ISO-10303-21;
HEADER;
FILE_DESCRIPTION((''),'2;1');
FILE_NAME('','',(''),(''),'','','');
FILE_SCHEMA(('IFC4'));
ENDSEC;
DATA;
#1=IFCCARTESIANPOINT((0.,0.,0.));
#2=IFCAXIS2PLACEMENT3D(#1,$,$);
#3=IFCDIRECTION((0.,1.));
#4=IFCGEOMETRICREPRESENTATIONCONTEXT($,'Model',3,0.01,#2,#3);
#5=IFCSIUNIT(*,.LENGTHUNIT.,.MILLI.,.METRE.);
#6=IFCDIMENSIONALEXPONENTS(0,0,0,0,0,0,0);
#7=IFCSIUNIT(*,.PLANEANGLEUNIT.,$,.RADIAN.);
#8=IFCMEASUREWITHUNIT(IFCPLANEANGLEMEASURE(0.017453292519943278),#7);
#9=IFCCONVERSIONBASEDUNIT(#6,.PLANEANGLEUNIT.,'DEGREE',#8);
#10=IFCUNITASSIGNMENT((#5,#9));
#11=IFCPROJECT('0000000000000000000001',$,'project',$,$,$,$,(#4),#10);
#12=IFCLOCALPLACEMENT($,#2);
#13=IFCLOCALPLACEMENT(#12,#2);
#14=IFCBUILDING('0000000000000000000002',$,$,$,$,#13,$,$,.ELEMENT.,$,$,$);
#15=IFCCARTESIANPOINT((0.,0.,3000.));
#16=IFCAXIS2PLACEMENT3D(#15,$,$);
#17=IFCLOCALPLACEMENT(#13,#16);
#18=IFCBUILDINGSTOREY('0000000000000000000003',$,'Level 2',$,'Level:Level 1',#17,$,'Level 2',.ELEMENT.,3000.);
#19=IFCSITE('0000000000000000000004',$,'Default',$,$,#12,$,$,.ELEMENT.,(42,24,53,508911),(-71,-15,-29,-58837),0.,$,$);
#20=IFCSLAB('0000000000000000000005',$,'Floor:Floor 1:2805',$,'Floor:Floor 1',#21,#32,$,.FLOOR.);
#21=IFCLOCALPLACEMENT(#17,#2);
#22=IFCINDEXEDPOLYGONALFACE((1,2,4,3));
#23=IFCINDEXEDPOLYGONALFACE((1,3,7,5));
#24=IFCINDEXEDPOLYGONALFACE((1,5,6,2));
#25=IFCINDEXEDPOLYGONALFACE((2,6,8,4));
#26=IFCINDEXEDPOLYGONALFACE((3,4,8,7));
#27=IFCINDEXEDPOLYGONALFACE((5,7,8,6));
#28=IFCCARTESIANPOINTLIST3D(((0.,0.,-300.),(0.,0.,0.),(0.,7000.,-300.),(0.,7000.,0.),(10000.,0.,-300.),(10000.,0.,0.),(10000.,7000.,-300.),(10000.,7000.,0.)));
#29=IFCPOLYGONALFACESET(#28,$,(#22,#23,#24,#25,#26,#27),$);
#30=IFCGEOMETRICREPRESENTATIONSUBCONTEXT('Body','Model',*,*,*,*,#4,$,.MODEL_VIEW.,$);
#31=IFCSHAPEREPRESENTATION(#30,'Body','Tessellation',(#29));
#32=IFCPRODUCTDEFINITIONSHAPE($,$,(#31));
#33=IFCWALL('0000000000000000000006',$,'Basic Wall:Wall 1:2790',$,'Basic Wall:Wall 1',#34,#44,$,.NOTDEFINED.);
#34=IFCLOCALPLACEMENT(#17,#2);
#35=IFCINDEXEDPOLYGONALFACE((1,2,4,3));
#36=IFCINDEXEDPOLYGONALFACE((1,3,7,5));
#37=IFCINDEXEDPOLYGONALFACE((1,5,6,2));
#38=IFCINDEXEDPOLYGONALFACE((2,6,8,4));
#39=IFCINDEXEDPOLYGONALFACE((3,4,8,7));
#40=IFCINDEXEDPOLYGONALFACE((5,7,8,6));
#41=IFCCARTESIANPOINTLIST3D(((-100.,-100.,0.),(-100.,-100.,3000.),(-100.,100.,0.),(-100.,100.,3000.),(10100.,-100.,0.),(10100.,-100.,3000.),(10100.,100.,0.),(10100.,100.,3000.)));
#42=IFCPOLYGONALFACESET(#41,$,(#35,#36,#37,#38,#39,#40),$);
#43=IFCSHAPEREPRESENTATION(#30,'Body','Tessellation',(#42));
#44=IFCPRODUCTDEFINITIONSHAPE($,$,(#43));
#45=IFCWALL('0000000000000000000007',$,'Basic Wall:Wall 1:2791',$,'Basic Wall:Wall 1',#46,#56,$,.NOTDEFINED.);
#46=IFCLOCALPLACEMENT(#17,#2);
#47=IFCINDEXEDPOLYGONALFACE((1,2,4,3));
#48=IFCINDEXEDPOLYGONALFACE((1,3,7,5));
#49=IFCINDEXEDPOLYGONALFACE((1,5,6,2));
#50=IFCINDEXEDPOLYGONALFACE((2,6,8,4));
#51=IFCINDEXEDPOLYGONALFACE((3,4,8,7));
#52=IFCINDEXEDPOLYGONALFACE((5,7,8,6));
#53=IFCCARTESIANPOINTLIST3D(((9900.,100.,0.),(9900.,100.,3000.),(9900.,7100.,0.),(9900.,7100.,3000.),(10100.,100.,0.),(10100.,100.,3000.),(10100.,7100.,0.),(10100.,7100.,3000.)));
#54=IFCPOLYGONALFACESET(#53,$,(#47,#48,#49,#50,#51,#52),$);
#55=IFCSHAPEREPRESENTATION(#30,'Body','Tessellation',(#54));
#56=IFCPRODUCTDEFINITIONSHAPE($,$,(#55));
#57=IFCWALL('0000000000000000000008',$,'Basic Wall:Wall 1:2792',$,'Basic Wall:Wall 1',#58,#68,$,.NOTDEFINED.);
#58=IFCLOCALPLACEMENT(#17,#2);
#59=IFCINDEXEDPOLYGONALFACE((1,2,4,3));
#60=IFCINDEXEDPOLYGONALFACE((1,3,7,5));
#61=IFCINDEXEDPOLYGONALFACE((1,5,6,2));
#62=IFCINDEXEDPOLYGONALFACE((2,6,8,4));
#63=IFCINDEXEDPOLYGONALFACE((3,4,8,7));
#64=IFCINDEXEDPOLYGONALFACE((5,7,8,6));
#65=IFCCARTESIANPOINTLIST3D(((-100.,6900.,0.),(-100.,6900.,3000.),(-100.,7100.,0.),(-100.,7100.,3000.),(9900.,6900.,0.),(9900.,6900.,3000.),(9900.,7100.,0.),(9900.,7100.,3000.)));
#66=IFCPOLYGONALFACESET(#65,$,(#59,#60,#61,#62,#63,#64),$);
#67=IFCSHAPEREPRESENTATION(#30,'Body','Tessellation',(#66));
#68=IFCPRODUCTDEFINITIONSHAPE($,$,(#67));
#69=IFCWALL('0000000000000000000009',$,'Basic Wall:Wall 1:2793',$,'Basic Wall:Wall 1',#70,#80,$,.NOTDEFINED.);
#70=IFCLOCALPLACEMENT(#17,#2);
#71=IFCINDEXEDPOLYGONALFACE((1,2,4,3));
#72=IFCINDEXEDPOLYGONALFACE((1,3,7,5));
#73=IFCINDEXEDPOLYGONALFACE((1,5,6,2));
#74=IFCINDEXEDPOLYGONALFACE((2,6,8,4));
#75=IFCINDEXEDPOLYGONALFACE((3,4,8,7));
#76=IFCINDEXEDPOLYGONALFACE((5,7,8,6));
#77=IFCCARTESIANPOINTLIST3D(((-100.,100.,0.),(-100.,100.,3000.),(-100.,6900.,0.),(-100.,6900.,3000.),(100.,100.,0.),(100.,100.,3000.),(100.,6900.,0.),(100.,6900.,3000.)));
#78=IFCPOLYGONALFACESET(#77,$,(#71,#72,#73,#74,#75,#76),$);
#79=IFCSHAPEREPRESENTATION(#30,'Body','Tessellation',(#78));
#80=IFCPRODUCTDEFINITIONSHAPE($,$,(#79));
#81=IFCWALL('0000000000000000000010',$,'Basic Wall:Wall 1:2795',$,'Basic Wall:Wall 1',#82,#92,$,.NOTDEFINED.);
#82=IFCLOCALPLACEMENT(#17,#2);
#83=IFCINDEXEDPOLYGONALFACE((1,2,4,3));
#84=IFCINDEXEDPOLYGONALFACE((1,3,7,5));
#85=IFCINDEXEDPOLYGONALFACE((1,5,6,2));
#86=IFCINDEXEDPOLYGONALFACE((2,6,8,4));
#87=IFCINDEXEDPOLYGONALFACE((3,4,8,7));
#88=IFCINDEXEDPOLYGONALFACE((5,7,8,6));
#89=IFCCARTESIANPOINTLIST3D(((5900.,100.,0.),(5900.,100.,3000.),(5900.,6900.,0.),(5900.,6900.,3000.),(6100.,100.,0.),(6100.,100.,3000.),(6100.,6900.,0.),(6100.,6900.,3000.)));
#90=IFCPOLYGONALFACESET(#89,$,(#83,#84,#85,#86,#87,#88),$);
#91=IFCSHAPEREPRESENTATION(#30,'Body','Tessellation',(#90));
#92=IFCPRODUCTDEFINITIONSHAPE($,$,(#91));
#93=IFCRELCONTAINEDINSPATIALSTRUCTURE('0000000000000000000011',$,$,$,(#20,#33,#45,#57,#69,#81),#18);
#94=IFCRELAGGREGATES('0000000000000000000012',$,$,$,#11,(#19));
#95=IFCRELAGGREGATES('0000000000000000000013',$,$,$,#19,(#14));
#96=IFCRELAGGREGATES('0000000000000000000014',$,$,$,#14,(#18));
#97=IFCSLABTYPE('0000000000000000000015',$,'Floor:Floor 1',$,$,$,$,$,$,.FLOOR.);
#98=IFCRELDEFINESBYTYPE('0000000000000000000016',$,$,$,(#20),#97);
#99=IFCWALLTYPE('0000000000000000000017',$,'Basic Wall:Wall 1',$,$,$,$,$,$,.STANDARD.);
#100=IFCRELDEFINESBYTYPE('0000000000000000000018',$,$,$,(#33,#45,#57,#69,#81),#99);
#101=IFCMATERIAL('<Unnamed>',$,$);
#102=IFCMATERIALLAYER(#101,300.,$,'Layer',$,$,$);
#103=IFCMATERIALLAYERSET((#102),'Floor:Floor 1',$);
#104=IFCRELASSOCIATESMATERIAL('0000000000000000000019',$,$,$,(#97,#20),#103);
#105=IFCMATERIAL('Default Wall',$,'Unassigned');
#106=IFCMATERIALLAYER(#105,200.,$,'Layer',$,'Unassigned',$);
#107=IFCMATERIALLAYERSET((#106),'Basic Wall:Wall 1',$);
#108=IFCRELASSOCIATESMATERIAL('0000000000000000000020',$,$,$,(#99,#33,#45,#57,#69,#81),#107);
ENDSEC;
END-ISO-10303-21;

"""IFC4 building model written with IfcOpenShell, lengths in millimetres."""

from ifc_helpers import new_model, entity, si_unit, converted_unit, direction, frame, frame_2d, origin, origin_2d_with_axis, place, context, subcontext, project, spatial, rectangle, extrude, material, layer, layer_set, layer_usage, type_object, element, save


model = new_model("IFC4")

# Units and contexts
model_context = context("Model", 3, precision=0.01, world=origin(), true_north=direction((0.0, 1.0)))
body_context = subcontext(model_context, "Body", "Model", "MODEL_VIEW")
ifc_project = project(units=[si_unit("LENGTHUNIT", "METRE", prefix="MILLI"), converted_unit("PLANEANGLEUNIT", "DEGREE", entity("IfcPlaneAngleMeasure", 0.017453292519943278), si_unit("PLANEANGLEUNIT", "RADIAN"), dimensions=[0, 0, 0, 0, 0, 0, 0])], contexts=[model_context])

# Site, building, storey
site_placement = place(None, origin())
site = spatial("IfcSite", under=ifc_project, at=site_placement, Name="Default", CompositionType="ELEMENT", RefLatitude=(42, 24, 53, 508911), RefLongitude=(-71, -15, -29, -58837), RefElevation=0.0)
building_placement = place(site_placement, origin())
building = spatial("IfcBuilding", under=site, at=building_placement, CompositionType="ELEMENT")
storey_placement = place(building_placement, frame((0.0, 0.0, 3000.0)))
storey = spatial("IfcBuildingStorey", under=building, at=storey_placement, Name="Level 2", ObjectType="Level:Level 1", LongName="Level 2", CompositionType="ELEMENT", Elevation=3000.0)

# Slab
ifc_material_1 = material(Name="<Unnamed>")
ifc_layer_1 = layer(ifc_material_1, 300.0, Name="Layer")
ifc_layer_set_1 = layer_set([ifc_layer_1], Name="Floor:Floor 1")
ifc_layer_usage_1 = layer_usage(ifc_layer_set_1, "AXIS3", "POSITIVE", 0.0)
slab_type = type_object("IfcSlabType", Name="Floor:Floor 1", PredefinedType="FLOOR", material=ifc_layer_set_1)
slab_placement = place(storey_placement, origin())
element("IfcSlab", 1, at=slab_placement, inside=storey, type_object=slab_type, material=ifc_layer_usage_1, Name="Floor:Floor 1:2805", ObjectType="Floor:Floor 1", PredefinedType="FLOOR", context=body_context, shape_type="SweptSolid", body=[
    extrude(rectangle(XDim=7000.0, YDim=10000.0, at=origin_2d_with_axis()), frame((5000.0, 3500.0, 0.0), z_axis=(0.0, 0.0, -1.0), x_axis=(0.0, 1.0, 0.0)), (0.0, 0.0, 1.0), 300.0),
])

# Walls
ifc_material_2 = material(Name="Default Wall", Category="Unassigned")
ifc_layer_2 = layer(ifc_material_2, 200.0, Name="Layer", Category="Unassigned")
ifc_layer_set_2 = layer_set([ifc_layer_2], Name="Basic Wall:Wall 1")
ifc_layer_usage_2 = layer_usage(ifc_layer_set_2, "AXIS2", "NEGATIVE", 100.0)
wall_type = type_object("IfcWallType", Name="Basic Wall:Wall 1", PredefinedType="STANDARD", material=ifc_layer_set_2)
wall_1_placement = place(storey_placement, frame((-100.0, 0.0, 0.0)))
element("IfcWall", 2, at=wall_1_placement, inside=storey, type_object=wall_type, material=ifc_layer_usage_2, Name="Basic Wall:Wall 1:2790", ObjectType="Basic Wall:Wall 1", PredefinedType="NOTDEFINED", context=body_context, shape_type="SweptSolid", body=[
    extrude(rectangle(XDim=10200.0, YDim=200.0, at=frame_2d((5100.0, 0.0), x_axis=(-1.0, 0.0))), origin(), (0.0, 0.0, 1.0), 3000.0),
])
ifc_layer_usage_3 = layer_usage(ifc_layer_set_2, "AXIS2", "NEGATIVE", 100.0)
wall_2_placement = place(storey_placement, frame((10000.0, 100.0, 0.0), z_axis=(0.0, 0.0, 1.0), x_axis=(0.0, 1.0, 0.0)))
element("IfcWall", 3, at=wall_2_placement, inside=storey, type_object=wall_type, material=ifc_layer_usage_3, Name="Basic Wall:Wall 1:2791", ObjectType="Basic Wall:Wall 1", PredefinedType="NOTDEFINED", context=body_context, shape_type="SweptSolid", body=[
    extrude(rectangle(XDim=7000.0, YDim=200.0, at=frame_2d((3500.0, 0.0), x_axis=(-1.0, 0.0))), origin(), (0.0, 0.0, 1.0), 3000.0),
])
ifc_layer_usage_4 = layer_usage(ifc_layer_set_2, "AXIS2", "NEGATIVE", 100.0)
wall_3_placement = place(storey_placement, frame((9900.0, 7000.0, 0.0), z_axis=(0.0, 0.0, 1.0), x_axis=(-1.0, 0.0, 0.0)))
element("IfcWall", 4, at=wall_3_placement, inside=storey, type_object=wall_type, material=ifc_layer_usage_4, Name="Basic Wall:Wall 1:2792", ObjectType="Basic Wall:Wall 1", PredefinedType="NOTDEFINED", context=body_context, shape_type="SweptSolid", body=[
    extrude(rectangle(XDim=10000.0, YDim=200.0, at=frame_2d((5000.0, 0.0), x_axis=(-1.0, 0.0))), origin(), (0.0, 0.0, 1.0), 3000.0),
])
ifc_layer_usage_5 = layer_usage(ifc_layer_set_2, "AXIS2", "NEGATIVE", 100.0)
wall_4_placement = place(storey_placement, frame((0.0, 6900.0, 0.0), z_axis=(0.0, 0.0, 1.0), x_axis=(0.0, -1.0, 0.0)))
element("IfcWall", 5, at=wall_4_placement, inside=storey, type_object=wall_type, material=ifc_layer_usage_5, Name="Basic Wall:Wall 1:2793", ObjectType="Basic Wall:Wall 1", PredefinedType="NOTDEFINED", context=body_context, shape_type="SweptSolid", body=[
    extrude(rectangle(XDim=6800.0, YDim=200.0, at=frame_2d((3400.0, 0.0), x_axis=(-1.0, 0.0))), origin(), (0.0, 0.0, 1.0), 3000.0),
])
ifc_layer_usage_6 = layer_usage(ifc_layer_set_2, "AXIS2", "NEGATIVE", 100.0)
wall_5_placement = place(storey_placement, frame((6000.0, 100.0, 0.0), z_axis=(0.0, 0.0, 1.0), x_axis=(0.0, 1.0, 0.0)))
element("IfcWall", 6, at=wall_5_placement, inside=storey, type_object=wall_type, material=ifc_layer_usage_6, Name="Basic Wall:Wall 1:2795", ObjectType="Basic Wall:Wall 1", PredefinedType="NOTDEFINED", context=body_context, shape_type="SweptSolid", body=[
    extrude(rectangle(XDim=6800.0, YDim=200.0, at=frame_2d((3400.0, 0.0), x_axis=(-1.0, 0.0))), origin(), (0.0, 0.0, 1.0), 3000.0),
])

save(model, "model.ifc")
